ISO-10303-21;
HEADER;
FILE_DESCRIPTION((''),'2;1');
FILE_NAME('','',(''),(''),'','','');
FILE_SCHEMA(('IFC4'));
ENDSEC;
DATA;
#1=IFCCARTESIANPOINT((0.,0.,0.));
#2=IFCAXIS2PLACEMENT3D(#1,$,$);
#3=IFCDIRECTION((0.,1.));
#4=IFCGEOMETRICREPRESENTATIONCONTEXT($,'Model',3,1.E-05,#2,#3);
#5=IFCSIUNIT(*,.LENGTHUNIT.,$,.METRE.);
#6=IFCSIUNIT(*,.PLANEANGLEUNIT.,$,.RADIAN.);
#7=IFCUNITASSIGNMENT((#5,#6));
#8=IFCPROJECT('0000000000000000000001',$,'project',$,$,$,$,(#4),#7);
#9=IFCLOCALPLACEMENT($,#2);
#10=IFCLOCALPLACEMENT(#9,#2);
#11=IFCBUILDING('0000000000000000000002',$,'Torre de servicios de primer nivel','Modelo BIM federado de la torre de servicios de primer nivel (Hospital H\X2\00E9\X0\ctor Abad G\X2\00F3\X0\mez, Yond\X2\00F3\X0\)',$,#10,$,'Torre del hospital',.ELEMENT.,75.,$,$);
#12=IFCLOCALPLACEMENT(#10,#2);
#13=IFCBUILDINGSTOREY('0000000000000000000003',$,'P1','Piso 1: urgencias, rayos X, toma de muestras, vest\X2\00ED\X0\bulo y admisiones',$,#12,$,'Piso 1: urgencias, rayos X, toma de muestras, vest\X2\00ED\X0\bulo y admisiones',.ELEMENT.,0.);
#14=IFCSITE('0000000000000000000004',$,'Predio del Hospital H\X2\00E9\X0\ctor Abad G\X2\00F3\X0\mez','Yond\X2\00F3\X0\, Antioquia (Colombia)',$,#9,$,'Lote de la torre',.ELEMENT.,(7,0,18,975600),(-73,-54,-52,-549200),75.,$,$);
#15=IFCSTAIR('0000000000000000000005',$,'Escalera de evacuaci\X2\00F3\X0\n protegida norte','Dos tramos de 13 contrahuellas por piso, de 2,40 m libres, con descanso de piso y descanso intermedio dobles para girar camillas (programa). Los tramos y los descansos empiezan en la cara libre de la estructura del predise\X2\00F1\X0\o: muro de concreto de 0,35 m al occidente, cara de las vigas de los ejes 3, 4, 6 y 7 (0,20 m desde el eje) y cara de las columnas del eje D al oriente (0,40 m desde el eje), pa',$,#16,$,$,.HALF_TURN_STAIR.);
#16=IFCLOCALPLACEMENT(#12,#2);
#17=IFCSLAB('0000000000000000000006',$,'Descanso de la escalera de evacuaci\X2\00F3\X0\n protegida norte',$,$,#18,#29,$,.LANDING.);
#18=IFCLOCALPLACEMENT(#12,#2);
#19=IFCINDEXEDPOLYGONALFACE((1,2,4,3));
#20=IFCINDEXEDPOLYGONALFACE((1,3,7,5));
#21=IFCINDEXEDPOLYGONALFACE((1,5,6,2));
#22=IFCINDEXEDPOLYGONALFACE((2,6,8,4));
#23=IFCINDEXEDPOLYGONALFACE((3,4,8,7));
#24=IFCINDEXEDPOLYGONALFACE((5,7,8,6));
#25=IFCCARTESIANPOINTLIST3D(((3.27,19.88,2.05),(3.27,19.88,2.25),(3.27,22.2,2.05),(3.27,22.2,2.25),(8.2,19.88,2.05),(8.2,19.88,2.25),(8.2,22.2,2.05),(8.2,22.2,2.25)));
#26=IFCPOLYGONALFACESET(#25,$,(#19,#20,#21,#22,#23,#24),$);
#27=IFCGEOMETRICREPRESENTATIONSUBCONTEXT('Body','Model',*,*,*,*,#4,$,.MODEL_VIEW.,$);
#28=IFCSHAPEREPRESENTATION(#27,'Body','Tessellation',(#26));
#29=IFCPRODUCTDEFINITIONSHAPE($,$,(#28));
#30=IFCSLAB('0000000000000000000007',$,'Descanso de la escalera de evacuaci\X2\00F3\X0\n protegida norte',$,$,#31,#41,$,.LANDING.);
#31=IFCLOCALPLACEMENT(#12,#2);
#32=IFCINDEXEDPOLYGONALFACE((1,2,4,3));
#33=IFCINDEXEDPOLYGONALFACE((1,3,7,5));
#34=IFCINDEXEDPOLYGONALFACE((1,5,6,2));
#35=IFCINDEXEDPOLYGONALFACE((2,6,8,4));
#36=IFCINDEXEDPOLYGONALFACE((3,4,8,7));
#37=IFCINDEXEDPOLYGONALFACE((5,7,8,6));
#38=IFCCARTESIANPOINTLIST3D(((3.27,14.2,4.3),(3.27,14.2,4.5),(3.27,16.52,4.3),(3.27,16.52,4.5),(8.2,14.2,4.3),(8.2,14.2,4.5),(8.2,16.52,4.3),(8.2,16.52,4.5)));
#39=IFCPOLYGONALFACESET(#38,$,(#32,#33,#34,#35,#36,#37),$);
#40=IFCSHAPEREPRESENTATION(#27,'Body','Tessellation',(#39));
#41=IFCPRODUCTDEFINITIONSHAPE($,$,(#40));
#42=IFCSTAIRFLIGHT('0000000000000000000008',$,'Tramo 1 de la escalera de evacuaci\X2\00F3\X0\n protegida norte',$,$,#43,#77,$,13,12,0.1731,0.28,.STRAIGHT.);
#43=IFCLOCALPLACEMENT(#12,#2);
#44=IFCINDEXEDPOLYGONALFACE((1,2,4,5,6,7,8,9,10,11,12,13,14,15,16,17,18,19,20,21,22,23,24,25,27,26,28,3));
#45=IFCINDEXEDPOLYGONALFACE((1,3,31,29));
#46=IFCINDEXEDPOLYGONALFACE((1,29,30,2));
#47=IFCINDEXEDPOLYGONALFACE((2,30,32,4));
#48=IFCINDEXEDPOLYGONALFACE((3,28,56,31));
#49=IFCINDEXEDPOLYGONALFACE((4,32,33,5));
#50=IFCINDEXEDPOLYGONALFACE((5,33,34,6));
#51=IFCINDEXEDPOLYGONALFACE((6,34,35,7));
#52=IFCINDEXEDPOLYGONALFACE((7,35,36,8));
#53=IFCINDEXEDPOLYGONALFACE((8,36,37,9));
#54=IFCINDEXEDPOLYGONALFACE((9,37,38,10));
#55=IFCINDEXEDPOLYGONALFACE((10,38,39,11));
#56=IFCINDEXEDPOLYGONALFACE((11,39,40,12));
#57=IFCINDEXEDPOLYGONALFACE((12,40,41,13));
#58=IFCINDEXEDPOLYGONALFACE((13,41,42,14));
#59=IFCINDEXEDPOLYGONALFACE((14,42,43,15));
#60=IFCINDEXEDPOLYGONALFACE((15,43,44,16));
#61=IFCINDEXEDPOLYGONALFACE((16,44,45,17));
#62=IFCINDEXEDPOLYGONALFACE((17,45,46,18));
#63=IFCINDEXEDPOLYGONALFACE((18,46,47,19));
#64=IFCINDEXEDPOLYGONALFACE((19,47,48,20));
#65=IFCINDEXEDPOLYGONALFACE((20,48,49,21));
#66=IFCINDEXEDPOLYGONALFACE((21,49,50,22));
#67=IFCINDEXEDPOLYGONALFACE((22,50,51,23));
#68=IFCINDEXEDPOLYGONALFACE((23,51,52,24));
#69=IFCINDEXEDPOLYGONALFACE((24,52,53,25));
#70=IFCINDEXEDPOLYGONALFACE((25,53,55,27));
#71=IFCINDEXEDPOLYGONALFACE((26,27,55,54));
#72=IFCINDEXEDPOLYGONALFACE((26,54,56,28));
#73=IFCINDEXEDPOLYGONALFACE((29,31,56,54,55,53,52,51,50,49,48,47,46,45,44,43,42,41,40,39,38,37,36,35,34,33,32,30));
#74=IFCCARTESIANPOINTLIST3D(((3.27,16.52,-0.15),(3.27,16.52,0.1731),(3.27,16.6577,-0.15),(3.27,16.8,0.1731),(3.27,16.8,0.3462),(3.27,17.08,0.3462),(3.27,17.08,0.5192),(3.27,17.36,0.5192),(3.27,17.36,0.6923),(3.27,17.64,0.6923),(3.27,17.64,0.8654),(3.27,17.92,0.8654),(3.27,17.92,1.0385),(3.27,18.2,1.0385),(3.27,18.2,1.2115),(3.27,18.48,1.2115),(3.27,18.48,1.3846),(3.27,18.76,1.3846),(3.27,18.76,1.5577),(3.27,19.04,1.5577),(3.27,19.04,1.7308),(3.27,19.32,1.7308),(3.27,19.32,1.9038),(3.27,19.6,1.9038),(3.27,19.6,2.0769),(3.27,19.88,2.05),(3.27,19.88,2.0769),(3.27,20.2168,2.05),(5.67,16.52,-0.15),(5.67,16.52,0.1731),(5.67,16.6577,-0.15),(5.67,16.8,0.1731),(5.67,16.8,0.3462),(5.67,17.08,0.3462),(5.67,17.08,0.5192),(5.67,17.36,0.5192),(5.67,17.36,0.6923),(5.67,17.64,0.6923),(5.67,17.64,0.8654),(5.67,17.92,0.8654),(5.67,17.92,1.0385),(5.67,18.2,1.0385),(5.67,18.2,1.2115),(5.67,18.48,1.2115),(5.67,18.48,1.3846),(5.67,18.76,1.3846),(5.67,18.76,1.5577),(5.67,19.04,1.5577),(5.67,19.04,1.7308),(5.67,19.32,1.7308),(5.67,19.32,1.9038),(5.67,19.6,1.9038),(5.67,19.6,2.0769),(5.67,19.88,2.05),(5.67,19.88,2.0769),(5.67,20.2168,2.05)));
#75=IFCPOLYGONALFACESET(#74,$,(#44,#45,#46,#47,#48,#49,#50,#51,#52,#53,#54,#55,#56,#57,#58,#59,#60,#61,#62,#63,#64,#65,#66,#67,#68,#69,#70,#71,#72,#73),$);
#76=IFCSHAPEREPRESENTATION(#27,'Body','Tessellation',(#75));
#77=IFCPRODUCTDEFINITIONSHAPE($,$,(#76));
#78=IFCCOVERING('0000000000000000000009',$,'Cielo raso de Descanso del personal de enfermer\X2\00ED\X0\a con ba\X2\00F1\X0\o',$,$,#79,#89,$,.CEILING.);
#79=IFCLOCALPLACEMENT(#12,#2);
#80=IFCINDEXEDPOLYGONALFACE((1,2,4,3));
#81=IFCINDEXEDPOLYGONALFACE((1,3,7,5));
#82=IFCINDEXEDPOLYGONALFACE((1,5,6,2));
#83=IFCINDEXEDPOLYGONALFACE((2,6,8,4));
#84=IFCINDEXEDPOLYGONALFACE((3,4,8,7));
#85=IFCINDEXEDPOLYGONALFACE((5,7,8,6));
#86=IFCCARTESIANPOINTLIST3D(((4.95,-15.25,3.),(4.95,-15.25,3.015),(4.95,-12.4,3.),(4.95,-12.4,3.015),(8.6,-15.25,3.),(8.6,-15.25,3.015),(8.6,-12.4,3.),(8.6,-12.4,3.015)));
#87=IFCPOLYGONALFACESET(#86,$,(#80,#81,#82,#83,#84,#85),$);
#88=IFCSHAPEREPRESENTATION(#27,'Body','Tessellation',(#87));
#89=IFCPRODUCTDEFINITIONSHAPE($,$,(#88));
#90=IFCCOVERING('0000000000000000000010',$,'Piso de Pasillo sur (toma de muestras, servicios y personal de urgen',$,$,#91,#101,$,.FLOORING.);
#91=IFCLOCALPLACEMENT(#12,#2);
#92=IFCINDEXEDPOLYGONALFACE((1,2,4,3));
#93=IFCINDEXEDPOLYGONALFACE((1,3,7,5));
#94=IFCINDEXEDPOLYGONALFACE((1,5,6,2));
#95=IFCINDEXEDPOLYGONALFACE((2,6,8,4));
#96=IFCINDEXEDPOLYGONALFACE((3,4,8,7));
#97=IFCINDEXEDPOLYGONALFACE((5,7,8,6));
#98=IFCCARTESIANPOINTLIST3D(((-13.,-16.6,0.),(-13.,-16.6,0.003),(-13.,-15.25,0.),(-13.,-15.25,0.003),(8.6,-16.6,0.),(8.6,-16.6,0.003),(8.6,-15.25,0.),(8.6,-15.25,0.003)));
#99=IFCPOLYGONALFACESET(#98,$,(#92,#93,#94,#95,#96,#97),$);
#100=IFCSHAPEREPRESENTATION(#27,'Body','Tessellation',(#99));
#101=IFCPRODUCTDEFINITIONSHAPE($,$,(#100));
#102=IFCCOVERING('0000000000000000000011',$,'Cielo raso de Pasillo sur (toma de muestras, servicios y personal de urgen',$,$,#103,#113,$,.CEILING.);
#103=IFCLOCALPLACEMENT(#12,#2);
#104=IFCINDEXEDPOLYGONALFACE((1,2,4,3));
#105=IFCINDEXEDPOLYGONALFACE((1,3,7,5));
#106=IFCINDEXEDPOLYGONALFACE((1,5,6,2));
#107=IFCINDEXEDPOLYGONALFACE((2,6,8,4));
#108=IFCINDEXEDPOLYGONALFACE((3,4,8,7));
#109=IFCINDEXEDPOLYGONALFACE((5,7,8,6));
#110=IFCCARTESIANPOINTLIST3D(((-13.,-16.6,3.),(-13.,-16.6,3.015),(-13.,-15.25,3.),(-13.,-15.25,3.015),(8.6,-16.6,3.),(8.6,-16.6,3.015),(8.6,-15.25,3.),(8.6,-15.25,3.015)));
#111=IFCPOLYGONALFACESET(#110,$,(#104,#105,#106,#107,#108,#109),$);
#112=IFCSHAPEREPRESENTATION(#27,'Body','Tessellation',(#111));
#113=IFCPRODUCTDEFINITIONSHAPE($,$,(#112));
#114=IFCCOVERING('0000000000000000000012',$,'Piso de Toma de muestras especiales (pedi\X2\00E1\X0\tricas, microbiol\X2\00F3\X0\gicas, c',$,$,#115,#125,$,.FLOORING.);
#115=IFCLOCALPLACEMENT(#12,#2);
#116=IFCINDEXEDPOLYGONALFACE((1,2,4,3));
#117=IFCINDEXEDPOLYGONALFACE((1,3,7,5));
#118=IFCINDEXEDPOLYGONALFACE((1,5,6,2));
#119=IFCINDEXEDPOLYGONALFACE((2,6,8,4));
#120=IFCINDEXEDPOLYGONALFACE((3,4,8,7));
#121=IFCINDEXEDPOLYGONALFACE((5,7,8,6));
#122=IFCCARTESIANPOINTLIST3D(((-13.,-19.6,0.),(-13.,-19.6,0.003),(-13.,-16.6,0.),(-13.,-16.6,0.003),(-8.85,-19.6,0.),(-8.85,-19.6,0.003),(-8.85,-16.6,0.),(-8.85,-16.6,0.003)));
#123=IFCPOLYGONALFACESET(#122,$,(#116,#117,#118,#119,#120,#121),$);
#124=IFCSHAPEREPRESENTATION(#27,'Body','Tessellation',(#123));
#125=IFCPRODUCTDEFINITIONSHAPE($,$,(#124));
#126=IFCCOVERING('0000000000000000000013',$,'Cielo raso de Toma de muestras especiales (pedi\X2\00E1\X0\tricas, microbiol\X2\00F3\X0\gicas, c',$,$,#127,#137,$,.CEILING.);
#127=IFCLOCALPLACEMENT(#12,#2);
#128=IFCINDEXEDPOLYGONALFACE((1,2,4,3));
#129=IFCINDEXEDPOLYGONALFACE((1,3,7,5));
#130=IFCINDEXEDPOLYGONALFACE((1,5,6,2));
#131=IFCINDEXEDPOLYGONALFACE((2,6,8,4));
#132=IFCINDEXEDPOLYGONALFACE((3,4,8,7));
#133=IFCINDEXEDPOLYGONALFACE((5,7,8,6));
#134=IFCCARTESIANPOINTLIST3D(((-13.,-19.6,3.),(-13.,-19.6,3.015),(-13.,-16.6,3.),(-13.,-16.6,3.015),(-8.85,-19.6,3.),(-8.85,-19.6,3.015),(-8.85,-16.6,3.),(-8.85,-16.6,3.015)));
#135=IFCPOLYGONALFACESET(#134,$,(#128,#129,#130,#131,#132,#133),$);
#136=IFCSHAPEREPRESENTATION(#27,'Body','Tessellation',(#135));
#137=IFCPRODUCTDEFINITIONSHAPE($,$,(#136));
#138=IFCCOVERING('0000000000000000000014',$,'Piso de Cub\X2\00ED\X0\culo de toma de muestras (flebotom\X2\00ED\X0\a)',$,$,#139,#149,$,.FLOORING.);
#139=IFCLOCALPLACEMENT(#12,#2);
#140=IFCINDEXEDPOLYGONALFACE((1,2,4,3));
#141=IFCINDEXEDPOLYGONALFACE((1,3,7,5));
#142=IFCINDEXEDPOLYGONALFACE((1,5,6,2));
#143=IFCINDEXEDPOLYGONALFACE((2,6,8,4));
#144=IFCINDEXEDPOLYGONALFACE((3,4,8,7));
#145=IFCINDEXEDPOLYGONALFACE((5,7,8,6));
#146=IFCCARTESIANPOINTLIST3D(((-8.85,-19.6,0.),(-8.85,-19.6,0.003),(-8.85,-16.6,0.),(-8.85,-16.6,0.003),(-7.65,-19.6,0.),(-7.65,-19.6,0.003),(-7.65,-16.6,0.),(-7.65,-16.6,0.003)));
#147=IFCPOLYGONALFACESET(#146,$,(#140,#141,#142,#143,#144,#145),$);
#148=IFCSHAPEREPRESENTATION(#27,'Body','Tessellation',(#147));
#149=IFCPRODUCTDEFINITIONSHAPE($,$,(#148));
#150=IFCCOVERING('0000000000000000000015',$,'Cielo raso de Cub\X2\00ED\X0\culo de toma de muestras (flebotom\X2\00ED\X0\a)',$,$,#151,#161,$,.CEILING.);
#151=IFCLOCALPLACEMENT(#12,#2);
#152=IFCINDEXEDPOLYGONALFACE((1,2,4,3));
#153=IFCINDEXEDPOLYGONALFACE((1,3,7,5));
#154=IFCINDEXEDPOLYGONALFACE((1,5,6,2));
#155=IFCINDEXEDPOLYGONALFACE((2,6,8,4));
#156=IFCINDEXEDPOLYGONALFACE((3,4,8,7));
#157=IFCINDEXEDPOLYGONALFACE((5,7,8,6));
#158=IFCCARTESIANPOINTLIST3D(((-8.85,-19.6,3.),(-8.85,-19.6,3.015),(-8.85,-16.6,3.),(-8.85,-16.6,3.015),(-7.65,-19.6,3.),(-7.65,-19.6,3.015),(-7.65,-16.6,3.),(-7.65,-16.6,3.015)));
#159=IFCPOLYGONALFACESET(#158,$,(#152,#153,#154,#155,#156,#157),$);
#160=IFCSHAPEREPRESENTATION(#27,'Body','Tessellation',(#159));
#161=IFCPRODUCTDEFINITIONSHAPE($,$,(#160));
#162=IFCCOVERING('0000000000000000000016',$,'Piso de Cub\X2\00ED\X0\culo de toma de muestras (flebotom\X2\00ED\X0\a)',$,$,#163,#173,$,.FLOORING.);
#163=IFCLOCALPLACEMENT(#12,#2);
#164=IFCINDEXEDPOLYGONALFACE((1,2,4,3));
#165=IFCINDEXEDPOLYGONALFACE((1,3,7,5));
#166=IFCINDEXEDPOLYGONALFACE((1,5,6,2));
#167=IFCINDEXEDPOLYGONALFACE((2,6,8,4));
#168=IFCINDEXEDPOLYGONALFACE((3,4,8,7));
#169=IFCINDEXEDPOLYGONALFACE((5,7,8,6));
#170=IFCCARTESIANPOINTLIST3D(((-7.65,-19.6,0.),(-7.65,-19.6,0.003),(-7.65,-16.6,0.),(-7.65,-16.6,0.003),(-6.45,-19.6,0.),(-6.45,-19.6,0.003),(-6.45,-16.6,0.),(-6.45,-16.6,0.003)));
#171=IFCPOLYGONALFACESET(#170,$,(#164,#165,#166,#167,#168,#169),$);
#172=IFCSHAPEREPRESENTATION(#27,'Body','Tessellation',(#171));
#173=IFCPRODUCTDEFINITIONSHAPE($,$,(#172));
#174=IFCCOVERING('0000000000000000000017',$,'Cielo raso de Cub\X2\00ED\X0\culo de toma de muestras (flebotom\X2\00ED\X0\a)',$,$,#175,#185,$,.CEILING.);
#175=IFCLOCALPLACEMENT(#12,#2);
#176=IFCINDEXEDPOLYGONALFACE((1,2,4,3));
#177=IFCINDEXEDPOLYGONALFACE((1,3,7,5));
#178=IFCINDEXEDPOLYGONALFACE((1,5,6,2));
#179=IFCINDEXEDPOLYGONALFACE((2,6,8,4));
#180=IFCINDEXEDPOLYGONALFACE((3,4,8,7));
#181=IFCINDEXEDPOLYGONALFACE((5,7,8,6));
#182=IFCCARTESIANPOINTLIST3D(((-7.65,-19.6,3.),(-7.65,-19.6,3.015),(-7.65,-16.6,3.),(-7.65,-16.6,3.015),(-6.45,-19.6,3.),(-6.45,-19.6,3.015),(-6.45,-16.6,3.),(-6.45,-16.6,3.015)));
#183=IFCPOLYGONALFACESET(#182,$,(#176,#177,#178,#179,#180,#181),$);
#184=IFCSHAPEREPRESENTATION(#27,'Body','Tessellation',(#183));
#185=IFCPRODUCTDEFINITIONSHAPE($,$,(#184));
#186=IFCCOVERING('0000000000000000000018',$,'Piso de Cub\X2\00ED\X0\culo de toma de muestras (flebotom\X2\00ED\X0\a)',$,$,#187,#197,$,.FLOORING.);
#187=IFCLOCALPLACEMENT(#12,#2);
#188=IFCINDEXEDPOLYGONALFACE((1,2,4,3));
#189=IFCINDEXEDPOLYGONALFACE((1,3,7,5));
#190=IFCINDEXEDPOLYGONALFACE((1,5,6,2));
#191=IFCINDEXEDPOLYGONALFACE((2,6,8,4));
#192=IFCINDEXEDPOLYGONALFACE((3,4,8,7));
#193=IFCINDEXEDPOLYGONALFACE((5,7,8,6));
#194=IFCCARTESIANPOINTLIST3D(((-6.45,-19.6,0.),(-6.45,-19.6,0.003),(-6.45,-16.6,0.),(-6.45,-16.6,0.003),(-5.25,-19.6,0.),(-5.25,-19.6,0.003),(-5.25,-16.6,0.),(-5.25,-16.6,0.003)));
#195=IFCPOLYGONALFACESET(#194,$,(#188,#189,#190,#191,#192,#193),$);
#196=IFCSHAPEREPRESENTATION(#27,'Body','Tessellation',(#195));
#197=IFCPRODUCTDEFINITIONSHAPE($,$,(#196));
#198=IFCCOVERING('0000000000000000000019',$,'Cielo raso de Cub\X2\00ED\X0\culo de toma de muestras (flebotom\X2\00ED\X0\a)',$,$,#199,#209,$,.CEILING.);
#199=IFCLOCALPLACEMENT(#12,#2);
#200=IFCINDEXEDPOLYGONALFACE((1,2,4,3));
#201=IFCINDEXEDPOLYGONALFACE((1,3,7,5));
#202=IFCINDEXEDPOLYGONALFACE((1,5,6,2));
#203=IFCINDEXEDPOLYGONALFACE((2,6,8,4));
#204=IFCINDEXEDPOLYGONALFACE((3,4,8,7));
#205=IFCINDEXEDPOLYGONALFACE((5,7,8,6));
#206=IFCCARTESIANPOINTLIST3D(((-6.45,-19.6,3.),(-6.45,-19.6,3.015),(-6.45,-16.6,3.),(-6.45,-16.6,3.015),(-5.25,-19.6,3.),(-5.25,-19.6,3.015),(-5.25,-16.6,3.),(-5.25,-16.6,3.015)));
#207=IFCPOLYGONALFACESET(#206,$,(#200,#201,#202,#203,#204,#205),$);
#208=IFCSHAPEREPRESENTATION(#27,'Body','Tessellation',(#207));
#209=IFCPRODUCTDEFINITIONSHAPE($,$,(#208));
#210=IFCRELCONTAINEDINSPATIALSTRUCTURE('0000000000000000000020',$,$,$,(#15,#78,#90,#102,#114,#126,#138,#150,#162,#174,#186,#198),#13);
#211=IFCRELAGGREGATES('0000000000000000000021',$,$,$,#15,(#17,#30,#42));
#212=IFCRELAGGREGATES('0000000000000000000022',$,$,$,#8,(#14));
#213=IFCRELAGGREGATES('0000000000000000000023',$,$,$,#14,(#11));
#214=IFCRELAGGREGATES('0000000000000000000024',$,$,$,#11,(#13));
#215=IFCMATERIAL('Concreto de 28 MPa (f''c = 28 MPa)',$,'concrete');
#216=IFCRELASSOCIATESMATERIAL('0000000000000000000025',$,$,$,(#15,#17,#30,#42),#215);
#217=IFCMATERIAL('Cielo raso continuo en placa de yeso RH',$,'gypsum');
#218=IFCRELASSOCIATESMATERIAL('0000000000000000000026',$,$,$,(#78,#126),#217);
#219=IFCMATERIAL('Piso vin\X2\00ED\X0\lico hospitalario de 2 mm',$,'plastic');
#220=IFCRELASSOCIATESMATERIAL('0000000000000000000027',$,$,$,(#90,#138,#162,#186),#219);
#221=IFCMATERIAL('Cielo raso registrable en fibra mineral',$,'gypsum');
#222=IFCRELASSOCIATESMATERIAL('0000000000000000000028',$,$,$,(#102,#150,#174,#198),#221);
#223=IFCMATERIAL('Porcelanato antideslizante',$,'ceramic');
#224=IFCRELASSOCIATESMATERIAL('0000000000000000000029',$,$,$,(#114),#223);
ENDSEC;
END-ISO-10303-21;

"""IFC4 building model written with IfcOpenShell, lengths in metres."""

from ifc_helpers import new_model, si_unit, direction, frame, origin, place, context, subcontext, project, spatial, indexed_curve, rectangle, outline, extrude, material, element, aggregate, save


model = new_model("IFC4")

# Units and contexts
model_context = context("Model", 3, precision=1e-05, world=origin(), true_north=direction((0.0, 1.0)))
body_context = subcontext(model_context, "Body", "Model", "MODEL_VIEW")
ifc_project = project(units=[si_unit("LENGTHUNIT", "METRE"), si_unit("PLANEANGLEUNIT", "RADIAN")], contexts=[model_context])

# Site, building, storey
site_placement = place(None, origin())
site = spatial("IfcSite", under=ifc_project, at=site_placement, Name="Predio del Hospital Héctor Abad Gómez", Description="Yondó, Antioquia (Colombia)", LongName="Lote de la torre", CompositionType="ELEMENT", RefLatitude=(7, 0, 18, 975600), RefLongitude=(-73, -54, -52, -549200), RefElevation=75.0)
building_placement = place(site_placement, origin())
building = spatial("IfcBuilding", under=site, at=building_placement, Name="Torre de servicios de primer nivel", Description="Modelo BIM federado de la torre de servicios de primer nivel (Hospital Héctor Abad Gómez, Yondó)", LongName="Torre del hospital", CompositionType="ELEMENT", ElevationOfRefHeight=75.0)
placement = place(building_placement, origin())
storey = spatial("IfcBuildingStorey", under=building, at=placement, Name="P1", Description="Piso 1: urgencias, rayos X, toma de muestras, vestíbulo y admisiones", LongName="Piso 1: urgencias, rayos X, toma de muestras, vestíbulo y admisiones", CompositionType="ELEMENT", Elevation=0.0)

# Stair, slabs, stair flight
ifc_material_1 = material(Name="Concreto de 28 MPa (f'c = 28 MPa)", Category="concrete")
stair = element("IfcStair", 1, at=placement, inside=storey, material=ifc_material_1, Name="Escalera de evacuación protegida norte", Description="Dos tramos de 13 contrahuellas por piso, de 2,40 m libres, con descanso de piso y descanso intermedio dobles para girar camillas (programa). Los tramos y los descansos empiezan en la cara libre de la estructura del prediseño: muro de concreto de 0,35 m al occidente, cara de las vigas de los ejes 3, 4, 6 y 7 (0,20 m desde el eje) y cara de las columnas del eje D al oriente (0,40 m desde el eje), pa", PredefinedType="HALF_TURN_STAIR")
slab_1 = element("IfcSlab", 2, at=placement, material=ifc_material_1, Name="Descanso de la escalera de evacuación protegida norte", PredefinedType="LANDING", context=body_context, shape_type="SweptSolid", body=[
    extrude(rectangle(XDim=4.93, YDim=2.32), frame((5.735, 21.04, 2.05)), (0.0, 0.0, 1.0), 0.2),
])
slab_2 = element("IfcSlab", 3, at=placement, material=ifc_material_1, Name="Descanso de la escalera de evacuación protegida norte", PredefinedType="LANDING", context=body_context, shape_type="SweptSolid", body=[
    extrude(rectangle(XDim=4.93, YDim=2.32), frame((5.735, 15.36, 4.3)), (0.0, 0.0, 1.0), 0.2),
])
stair_flight = element("IfcStairFlight", 4, at=placement, material=ifc_material_1, Name="Tramo 1 de la escalera de evacuación protegida norte", NumberOfRisers=13, NumberOfTreads=12, PredefinedType="STRAIGHT", RiserHeight=0.1731, TreadLength=0.28, context=body_context, shape_type="SweptSolid", body=[
    extrude(outline(indexed_curve([(0.0, -0.15), (0.0, 0.1731), (0.28, 0.1731), (0.28, 0.3462), (0.56, 0.3462), (0.56, 0.5192), (0.84, 0.5192), (0.84, 0.6923), (1.12, 0.6923), (1.12, 0.8654), (1.4, 0.8654), (1.4, 1.0385), (1.68, 1.0385), (1.68, 1.2115), (1.96, 1.2115), (1.96, 1.3846), (2.24, 1.3846), (2.24, 1.5577), (2.52, 1.5577), (2.52, 1.7308), (2.8, 1.7308), (2.8, 1.9038), (3.08, 1.9038), (3.08, 2.0769), (3.36, 2.0769), (3.36, 2.05), (3.6968, 2.05), (0.1377, -0.15), (0.0, -0.15)], self_intersect=False)), frame((3.27, 16.52, 0.0), z_axis=(1.0, 0.0, 0.0), x_axis=(0.0, 1.0, 0.0)), (0.0, 0.0, 1.0), 2.4),
])
aggregate(stair, [slab_1, slab_2, stair_flight])

# Coverings
ifc_material_2 = material(Name="Cielo raso continuo en placa de yeso RH", Category="gypsum")
element("IfcCovering", 5, at=placement, inside=storey, material=ifc_material_2, Name="Cielo raso de Descanso del personal de enfermería con baño", PredefinedType="CEILING", context=body_context, shape_type="SweptSolid", body=[
    extrude(outline(indexed_curve([(4.95, -15.25), (8.6, -15.25), (8.6, -12.4), (4.95, -12.4), (4.95, -15.25)], self_intersect=False)), frame((0.0, 0.0, 3.0)), (0.0, 0.0, 1.0), 0.015),
])
ifc_material_3 = material(Name="Piso vinílico hospitalario de 2 mm", Category="plastic")
element("IfcCovering", 6, at=placement, inside=storey, material=ifc_material_3, Name="Piso de Pasillo sur (toma de muestras, servicios y personal de urgen", PredefinedType="FLOORING", context=body_context, shape_type="SweptSolid", body=[
    extrude(outline(indexed_curve([(-13.0, -16.6), (8.6, -16.6), (8.6, -15.25), (-13.0, -15.25), (-13.0, -16.6)], self_intersect=False)), origin(), (0.0, 0.0, 1.0), 0.003),
])
ifc_material_4 = material(Name="Cielo raso registrable en fibra mineral", Category="gypsum")
element("IfcCovering", 7, at=placement, inside=storey, material=ifc_material_4, Name="Cielo raso de Pasillo sur (toma de muestras, servicios y personal de urgen", PredefinedType="CEILING", context=body_context, shape_type="SweptSolid", body=[
    extrude(outline(indexed_curve([(-13.0, -16.6), (8.6, -16.6), (8.6, -15.25), (-13.0, -15.25), (-13.0, -16.6)], self_intersect=False)), frame((0.0, 0.0, 3.0)), (0.0, 0.0, 1.0), 0.015),
])
ifc_material_5 = material(Name="Porcelanato antideslizante", Category="ceramic")
element("IfcCovering", 8, at=placement, inside=storey, material=ifc_material_5, Name="Piso de Toma de muestras especiales (pediátricas, microbiológicas, c", PredefinedType="FLOORING", context=body_context, shape_type="SweptSolid", body=[
    extrude(outline(indexed_curve([(-13.0, -19.6), (-8.85, -19.6), (-8.85, -16.6), (-13.0, -16.6), (-13.0, -19.6)], self_intersect=False)), origin(), (0.0, 0.0, 1.0), 0.003),
])
element("IfcCovering", 9, at=placement, inside=storey, material=ifc_material_2, Name="Cielo raso de Toma de muestras especiales (pediátricas, microbiológicas, c", PredefinedType="CEILING", context=body_context, shape_type="SweptSolid", body=[
    extrude(outline(indexed_curve([(-13.0, -19.6), (-8.85, -19.6), (-8.85, -16.6), (-13.0, -16.6), (-13.0, -19.6)], self_intersect=False)), frame((0.0, 0.0, 3.0)), (0.0, 0.0, 1.0), 0.015),
])
element("IfcCovering", 10, at=placement, inside=storey, material=ifc_material_3, Name="Piso de Cubículo de toma de muestras (flebotomía)", PredefinedType="FLOORING", context=body_context, shape_type="SweptSolid", body=[
    extrude(outline(indexed_curve([(-8.85, -19.6), (-7.65, -19.6), (-7.65, -16.6), (-8.85, -16.6), (-8.85, -19.6)], self_intersect=False)), origin(), (0.0, 0.0, 1.0), 0.003),
])
element("IfcCovering", 11, at=placement, inside=storey, material=ifc_material_4, Name="Cielo raso de Cubículo de toma de muestras (flebotomía)", PredefinedType="CEILING", context=body_context, shape_type="SweptSolid", body=[
    extrude(outline(indexed_curve([(-8.85, -19.6), (-7.65, -19.6), (-7.65, -16.6), (-8.85, -16.6), (-8.85, -19.6)], self_intersect=False)), frame((0.0, 0.0, 3.0)), (0.0, 0.0, 1.0), 0.015),
])
element("IfcCovering", 12, at=placement, inside=storey, material=ifc_material_3, Name="Piso de Cubículo de toma de muestras (flebotomía)", PredefinedType="FLOORING", context=body_context, shape_type="SweptSolid", body=[
    extrude(outline(indexed_curve([(-7.65, -19.6), (-6.45, -19.6), (-6.45, -16.6), (-7.65, -16.6), (-7.65, -19.6)], self_intersect=False)), origin(), (0.0, 0.0, 1.0), 0.003),
])
element("IfcCovering", 13, at=placement, inside=storey, material=ifc_material_4, Name="Cielo raso de Cubículo de toma de muestras (flebotomía)", PredefinedType="CEILING", context=body_context, shape_type="SweptSolid", body=[
    extrude(outline(indexed_curve([(-7.65, -19.6), (-6.45, -19.6), (-6.45, -16.6), (-7.65, -16.6), (-7.65, -19.6)], self_intersect=False)), frame((0.0, 0.0, 3.0)), (0.0, 0.0, 1.0), 0.015),
])
element("IfcCovering", 14, at=placement, inside=storey, material=ifc_material_3, Name="Piso de Cubículo de toma de muestras (flebotomía)", PredefinedType="FLOORING", context=body_context, shape_type="SweptSolid", body=[
    extrude(outline(indexed_curve([(-6.45, -19.6), (-5.25, -19.6), (-5.25, -16.6), (-6.45, -16.6), (-6.45, -19.6)], self_intersect=False)), origin(), (0.0, 0.0, 1.0), 0.003),
])
element("IfcCovering", 15, at=placement, inside=storey, material=ifc_material_4, Name="Cielo raso de Cubículo de toma de muestras (flebotomía)", PredefinedType="CEILING", context=body_context, shape_type="SweptSolid", body=[
    extrude(outline(indexed_curve([(-6.45, -19.6), (-5.25, -19.6), (-5.25, -16.6), (-6.45, -16.6), (-6.45, -19.6)], self_intersect=False)), frame((0.0, 0.0, 3.0)), (0.0, 0.0, 1.0), 0.015),
])

save(model, "model.ifc")
